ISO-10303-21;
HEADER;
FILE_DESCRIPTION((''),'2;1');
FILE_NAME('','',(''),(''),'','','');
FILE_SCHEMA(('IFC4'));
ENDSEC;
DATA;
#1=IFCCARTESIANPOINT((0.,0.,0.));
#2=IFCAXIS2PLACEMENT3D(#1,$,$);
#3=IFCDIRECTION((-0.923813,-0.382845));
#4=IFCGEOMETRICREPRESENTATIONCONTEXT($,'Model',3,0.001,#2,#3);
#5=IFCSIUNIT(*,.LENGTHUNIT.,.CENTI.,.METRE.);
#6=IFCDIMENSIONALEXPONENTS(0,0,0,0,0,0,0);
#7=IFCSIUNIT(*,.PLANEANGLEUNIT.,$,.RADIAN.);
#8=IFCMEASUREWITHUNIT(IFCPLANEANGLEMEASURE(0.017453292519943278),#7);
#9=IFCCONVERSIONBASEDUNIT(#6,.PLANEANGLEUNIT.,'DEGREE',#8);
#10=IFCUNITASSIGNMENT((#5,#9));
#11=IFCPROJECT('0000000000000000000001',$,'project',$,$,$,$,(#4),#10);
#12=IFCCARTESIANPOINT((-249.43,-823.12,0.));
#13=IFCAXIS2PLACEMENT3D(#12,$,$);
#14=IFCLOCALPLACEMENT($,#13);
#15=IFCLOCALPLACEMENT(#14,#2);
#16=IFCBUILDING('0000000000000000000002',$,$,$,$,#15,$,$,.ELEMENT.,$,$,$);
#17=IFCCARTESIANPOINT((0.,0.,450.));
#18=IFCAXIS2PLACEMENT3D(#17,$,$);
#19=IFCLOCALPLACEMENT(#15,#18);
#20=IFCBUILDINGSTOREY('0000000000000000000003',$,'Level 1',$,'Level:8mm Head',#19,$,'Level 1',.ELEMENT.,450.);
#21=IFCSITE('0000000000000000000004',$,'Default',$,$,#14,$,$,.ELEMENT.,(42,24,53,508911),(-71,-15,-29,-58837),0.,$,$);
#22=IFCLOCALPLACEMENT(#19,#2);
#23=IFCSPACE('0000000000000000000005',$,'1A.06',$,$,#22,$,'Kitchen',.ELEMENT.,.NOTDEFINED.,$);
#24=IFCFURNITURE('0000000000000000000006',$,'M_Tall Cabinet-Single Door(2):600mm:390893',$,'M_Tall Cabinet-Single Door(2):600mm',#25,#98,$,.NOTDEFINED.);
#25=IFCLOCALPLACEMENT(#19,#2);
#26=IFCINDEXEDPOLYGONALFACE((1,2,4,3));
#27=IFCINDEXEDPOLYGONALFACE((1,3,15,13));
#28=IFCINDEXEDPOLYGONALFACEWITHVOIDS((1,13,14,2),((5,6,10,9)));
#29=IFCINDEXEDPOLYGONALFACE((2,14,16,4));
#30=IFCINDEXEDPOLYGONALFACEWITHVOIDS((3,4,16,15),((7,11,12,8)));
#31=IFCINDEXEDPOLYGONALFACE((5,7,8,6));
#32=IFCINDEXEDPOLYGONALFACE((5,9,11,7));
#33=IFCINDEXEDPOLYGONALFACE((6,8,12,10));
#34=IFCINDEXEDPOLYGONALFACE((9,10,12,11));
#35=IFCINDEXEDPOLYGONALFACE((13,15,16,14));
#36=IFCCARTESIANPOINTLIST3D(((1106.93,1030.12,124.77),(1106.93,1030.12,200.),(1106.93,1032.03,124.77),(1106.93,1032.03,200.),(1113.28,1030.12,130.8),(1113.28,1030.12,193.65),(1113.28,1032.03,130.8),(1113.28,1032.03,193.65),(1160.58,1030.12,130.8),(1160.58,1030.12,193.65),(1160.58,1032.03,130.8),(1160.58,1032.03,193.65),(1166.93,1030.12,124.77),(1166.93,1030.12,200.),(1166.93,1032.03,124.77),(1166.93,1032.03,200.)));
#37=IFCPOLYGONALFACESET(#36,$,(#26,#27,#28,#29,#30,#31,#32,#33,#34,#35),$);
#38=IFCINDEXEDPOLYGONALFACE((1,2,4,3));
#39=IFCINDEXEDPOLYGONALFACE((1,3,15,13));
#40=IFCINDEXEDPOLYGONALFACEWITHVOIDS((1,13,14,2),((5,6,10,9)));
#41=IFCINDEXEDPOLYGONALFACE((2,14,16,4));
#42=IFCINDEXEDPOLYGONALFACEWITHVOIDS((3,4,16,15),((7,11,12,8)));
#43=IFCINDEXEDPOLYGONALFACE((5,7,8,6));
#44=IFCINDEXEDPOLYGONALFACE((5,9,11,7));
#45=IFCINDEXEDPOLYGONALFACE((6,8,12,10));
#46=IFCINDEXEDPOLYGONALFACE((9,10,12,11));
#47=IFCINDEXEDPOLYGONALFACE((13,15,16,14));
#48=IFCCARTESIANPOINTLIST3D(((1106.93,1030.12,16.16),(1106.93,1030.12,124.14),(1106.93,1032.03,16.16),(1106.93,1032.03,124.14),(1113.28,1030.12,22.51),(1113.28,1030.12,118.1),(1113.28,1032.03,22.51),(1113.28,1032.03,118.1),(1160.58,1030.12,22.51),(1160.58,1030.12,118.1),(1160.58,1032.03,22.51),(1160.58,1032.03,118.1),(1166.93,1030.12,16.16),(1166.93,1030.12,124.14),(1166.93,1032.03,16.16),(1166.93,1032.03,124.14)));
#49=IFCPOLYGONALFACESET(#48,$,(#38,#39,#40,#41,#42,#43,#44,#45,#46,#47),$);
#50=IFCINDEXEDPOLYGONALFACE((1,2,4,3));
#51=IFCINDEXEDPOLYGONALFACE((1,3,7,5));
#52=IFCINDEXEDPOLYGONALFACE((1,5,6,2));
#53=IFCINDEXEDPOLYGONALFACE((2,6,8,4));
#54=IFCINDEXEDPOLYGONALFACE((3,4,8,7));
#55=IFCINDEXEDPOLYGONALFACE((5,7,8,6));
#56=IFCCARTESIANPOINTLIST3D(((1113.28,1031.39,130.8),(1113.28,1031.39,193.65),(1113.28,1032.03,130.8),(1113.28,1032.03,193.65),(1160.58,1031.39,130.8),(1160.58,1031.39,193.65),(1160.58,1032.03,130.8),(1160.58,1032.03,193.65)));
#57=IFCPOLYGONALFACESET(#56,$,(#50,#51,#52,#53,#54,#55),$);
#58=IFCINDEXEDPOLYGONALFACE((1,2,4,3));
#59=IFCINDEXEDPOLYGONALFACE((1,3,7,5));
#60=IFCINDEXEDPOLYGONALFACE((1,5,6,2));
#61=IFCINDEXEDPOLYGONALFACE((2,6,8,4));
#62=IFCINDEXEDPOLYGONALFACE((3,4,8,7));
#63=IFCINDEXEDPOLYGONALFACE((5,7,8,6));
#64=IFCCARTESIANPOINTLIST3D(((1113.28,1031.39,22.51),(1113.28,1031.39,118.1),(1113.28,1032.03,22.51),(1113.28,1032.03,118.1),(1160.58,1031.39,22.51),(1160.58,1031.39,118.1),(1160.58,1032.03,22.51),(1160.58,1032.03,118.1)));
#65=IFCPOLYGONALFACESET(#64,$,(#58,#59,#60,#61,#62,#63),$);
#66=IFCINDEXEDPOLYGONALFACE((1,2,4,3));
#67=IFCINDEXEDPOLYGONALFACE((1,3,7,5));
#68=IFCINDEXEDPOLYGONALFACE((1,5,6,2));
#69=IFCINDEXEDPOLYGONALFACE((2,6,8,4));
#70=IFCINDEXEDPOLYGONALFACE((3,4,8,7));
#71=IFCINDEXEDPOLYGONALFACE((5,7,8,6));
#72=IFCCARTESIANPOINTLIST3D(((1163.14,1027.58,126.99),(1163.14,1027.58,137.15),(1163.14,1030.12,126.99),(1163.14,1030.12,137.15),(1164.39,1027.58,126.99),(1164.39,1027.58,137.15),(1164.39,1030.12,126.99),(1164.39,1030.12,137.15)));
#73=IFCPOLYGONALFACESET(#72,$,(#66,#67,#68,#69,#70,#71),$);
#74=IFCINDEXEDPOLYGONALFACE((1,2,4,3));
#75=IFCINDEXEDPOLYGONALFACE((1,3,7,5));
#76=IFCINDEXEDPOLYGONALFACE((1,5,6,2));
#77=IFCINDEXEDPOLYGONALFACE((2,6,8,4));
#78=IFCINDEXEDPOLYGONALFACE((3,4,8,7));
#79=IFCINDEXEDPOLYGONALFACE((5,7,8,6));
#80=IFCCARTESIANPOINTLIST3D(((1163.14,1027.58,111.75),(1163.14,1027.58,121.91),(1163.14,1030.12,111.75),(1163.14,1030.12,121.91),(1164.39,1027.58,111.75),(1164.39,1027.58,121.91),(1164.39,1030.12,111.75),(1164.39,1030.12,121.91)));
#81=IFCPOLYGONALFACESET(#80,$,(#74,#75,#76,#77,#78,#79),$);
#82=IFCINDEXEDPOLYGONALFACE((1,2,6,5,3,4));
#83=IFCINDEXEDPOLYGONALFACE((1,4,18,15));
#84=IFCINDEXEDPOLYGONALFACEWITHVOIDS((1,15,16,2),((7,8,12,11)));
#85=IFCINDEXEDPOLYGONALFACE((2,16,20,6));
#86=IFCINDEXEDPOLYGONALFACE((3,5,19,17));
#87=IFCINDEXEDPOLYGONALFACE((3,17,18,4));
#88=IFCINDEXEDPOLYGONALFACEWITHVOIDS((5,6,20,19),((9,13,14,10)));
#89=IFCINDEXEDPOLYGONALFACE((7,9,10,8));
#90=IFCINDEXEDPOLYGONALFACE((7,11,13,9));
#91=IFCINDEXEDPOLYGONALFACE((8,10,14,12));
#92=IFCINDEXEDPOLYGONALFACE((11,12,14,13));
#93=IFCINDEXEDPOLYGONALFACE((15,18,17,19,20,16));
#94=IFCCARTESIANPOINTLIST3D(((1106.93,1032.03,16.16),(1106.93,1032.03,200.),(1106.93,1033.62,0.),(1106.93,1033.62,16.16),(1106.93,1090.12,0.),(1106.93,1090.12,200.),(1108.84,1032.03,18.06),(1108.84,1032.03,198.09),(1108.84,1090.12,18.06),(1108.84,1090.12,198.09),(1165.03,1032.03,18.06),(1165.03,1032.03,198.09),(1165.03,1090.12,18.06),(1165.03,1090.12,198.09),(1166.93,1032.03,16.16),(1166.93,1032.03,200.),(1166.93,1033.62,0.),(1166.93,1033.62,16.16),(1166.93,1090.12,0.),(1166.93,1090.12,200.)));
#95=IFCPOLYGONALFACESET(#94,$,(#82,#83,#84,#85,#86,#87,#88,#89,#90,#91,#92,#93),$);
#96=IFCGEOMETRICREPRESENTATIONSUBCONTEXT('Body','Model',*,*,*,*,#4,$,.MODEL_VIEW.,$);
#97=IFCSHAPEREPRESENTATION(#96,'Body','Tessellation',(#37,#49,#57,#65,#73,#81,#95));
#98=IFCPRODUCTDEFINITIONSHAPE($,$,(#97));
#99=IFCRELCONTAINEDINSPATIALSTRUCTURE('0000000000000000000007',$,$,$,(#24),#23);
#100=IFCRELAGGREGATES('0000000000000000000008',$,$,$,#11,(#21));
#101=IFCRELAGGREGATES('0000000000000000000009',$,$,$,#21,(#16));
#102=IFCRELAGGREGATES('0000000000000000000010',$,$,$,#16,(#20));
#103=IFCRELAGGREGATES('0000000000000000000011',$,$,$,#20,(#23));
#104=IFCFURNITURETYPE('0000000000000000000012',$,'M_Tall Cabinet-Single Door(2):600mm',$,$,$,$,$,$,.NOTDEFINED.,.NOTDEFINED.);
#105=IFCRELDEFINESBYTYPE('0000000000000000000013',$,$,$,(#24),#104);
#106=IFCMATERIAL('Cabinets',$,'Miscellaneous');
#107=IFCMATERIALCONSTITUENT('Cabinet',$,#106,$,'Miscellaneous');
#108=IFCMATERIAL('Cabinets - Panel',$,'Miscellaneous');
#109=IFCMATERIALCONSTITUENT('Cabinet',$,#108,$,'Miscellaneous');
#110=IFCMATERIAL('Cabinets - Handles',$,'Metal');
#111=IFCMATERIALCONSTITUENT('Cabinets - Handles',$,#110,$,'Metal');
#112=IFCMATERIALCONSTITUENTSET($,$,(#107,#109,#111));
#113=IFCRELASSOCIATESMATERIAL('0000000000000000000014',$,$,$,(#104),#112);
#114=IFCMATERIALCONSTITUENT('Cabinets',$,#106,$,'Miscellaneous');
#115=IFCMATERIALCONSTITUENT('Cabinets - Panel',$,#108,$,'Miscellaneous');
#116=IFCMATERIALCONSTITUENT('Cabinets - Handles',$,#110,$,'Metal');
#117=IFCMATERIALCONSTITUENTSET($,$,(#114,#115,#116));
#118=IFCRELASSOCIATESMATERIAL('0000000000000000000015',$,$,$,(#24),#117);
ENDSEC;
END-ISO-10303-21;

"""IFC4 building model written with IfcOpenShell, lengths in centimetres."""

from ifc_helpers import new_model, entity, si_unit, converted_unit, direction, frame, origin, place, context, subcontext, project, spatial, indexed_curve, outline, extrude, source, transform, mapped, material, constituent, constituent_set, type_object, type_shapes, element, save


model = new_model("IFC4")

# Units and contexts
model_context = context("Model", 3, precision=0.001, world=origin(), true_north=direction((-0.923813, -0.382845)))
body_context = subcontext(model_context, "Body", "Model", "MODEL_VIEW")
ifc_project = project(units=[si_unit("LENGTHUNIT", "METRE", prefix="CENTI"), converted_unit("PLANEANGLEUNIT", "DEGREE", entity("IfcPlaneAngleMeasure", 0.017453292519943278), si_unit("PLANEANGLEUNIT", "RADIAN"), dimensions=[0, 0, 0, 0, 0, 0, 0])], contexts=[model_context])

# Site, building, storey
site_placement = place(None, frame((-249.43, -823.12, 0.0)))
site = spatial("IfcSite", under=ifc_project, at=site_placement, Name="Default", CompositionType="ELEMENT", RefLatitude=(42, 24, 53, 508911), RefLongitude=(-71, -15, -29, -58837), RefElevation=0.0)
building_placement = place(site_placement, origin())
building = spatial("IfcBuilding", under=site, at=building_placement, CompositionType="ELEMENT")
storey_placement = place(building_placement, frame((0.0, 0.0, 450.0)))
storey = spatial("IfcBuildingStorey", under=building, at=storey_placement, Name="Level 1", ObjectType="Level:8mm Head", LongName="Level 1", CompositionType="ELEMENT", Elevation=450.0)

# Shared definitions
space_1_placement = place(storey_placement, origin())
space_1 = spatial("IfcSpace", under=storey, at=space_1_placement, Name="1A.06", LongName="Kitchen", CompositionType="ELEMENT", PredefinedType="NOTDEFINED")

# Furniture, opening
ifc_material_1 = material(Name="Cabinets", Category="Miscellaneous")
ifc_material_2 = material(Name="Cabinets - Panel", Category="Miscellaneous")
ifc_material_3 = material(Name="Cabinets - Handles", Category="Metal")
ifc_constituent_1 = constituent(ifc_material_1, Name="Cabinets", Category="Miscellaneous")
ifc_constituent_2 = constituent(ifc_material_2, Name="Cabinets - Panel", Category="Miscellaneous")
ifc_constituent_3 = constituent(ifc_material_3, Name="Cabinets - Handles", Category="Metal")
ifc_constituent_set_1 = constituent_set(constituents=[ifc_constituent_1, ifc_constituent_2, ifc_constituent_3])
ifc_constituent_4 = constituent(ifc_material_1, Name="Cabinet", Category="Miscellaneous")
ifc_constituent_5 = constituent(ifc_material_2, Name="Cabinet", Category="Miscellaneous")
ifc_constituent_6 = constituent(ifc_material_3, Name="Cabinets - Handles", Category="Metal")
ifc_constituent_set_2 = constituent_set(constituents=[ifc_constituent_4, ifc_constituent_5, ifc_constituent_6])
furniture_type_1 = type_object("IfcFurnitureType", Name="M_Tall Cabinet-Single Door(2):600mm", AssemblyPlace="NOTDEFINED", PredefinedType="NOTDEFINED", material=ifc_constituent_set_2)
shared_shape_1 = source(origin(), body_context, "Body", "SweptSolid", [
    extrude(outline(indexed_curve([(-0.95, -28.09), (0.95, -28.09), (0.95, 28.09), (-0.95, 28.09), (-0.95, -28.09)], self_intersect=False)), frame((1.87, -0.95, 18.06), z_axis=(0.0, 0.0, 1.0), x_axis=(0.0, 1.0, 0.0)), (0.0, 0.0, 1.0), 180.03),
    extrude(outline(indexed_curve([(-37.61, -30.0), (37.61, -30.0), (37.61, 30.0), (-37.61, 30.0), (-37.61, -30.0)], self_intersect=False), holes=[indexed_curve([(-31.26, -23.65), (-31.26, 23.65), (31.58, 23.65), (31.58, -23.65), (-31.26, -23.65)], self_intersect=False)]), frame((1.87, -60.0, 162.39), z_axis=(0.0, 1.0, 0.0), x_axis=(0.0, 0.0, -1.0)), (0.0, 0.0, 1.0), 1.91),
    extrude(outline(indexed_curve([(-30.0, -53.99), (30.0, -53.99), (30.0, 53.99), (-30.0, 53.99), (-30.0, -53.99)], self_intersect=False), holes=[indexed_curve([(-23.65, 47.96), (23.65, 47.96), (23.65, -47.64), (-23.65, -47.64), (-23.65, 47.96)], self_intersect=False)]), frame((1.87, -60.0, 70.15), z_axis=(0.0, 1.0, 0.0), x_axis=(-1.0, 0.0, 0.0)), (0.0, 0.0, 1.0), 1.91),
    extrude(outline(indexed_curve([(-0.32, -23.65), (0.32, -23.65), (0.32, 23.65), (-0.32, 23.65), (-0.32, -23.65)], self_intersect=False)), frame((1.87, -58.41, 130.8), z_axis=(0.0, 0.0, 1.0), x_axis=(0.0, 1.0, 0.0)), (0.0, 0.0, 1.0), 62.85),
    extrude(outline(indexed_curve([(-0.32, -23.65), (0.32, -23.65), (0.32, 23.65), (-0.32, 23.65), (-0.32, -23.65)], self_intersect=False)), frame((1.87, -58.41, 22.51), z_axis=(0.0, 0.0, 1.0), x_axis=(0.0, 1.0, 0.0)), (0.0, 0.0, 1.0), 95.6),
    extrude(outline(indexed_curve([(-1.27, -0.63), (1.27, -0.63), (1.27, 0.63), (-1.27, 0.63), (-1.27, -0.63)], self_intersect=False)), frame((28.71, -61.27, 126.99), z_axis=(0.0, 0.0, 1.0), x_axis=(0.0, 1.0, 0.0)), (0.0, 0.0, 1.0), 10.16),
    extrude(outline(indexed_curve([(-1.27, -0.63), (1.27, -0.63), (1.27, 0.63), (-1.27, 0.63), (-1.27, -0.63)], self_intersect=False)), frame((28.71, -61.27, 111.75), z_axis=(0.0, 0.0, 1.0), x_axis=(0.0, 1.0, 0.0)), (0.0, 0.0, 1.0), 10.16),
    extrude(outline(indexed_curve([(-19.9, 55.89), (-19.9, -127.95), (38.2, -127.95), (38.2, 72.05), (-18.3, 72.05), (-18.3, 55.89), (-19.9, 55.89)], self_intersect=False)), frame((-28.13, -38.2, 72.05), z_axis=(-1.0, 0.0, 0.0), x_axis=(0.0, 1.0, 0.0)), (0.0, 0.0, -1.0), 60.0),
])
type_shapes(furniture_type_1, [shared_shape_1])
furniture_1_placement = place(space_1_placement, frame((1135.06, 1090.12, 0.0)))
furniture_1 = element("IfcFurniture", 1, at=furniture_1_placement, inside=space_1, type_object=furniture_type_1, material=ifc_constituent_set_1, Name="M_Tall Cabinet-Single Door(2):600mm:390893", ObjectType="M_Tall Cabinet-Single Door(2):600mm", PredefinedType="NOTDEFINED", context=body_context, shape_type="MappedRepresentation", body=[
    mapped(shared_shape_1, transform((0.0, 0.0, 0.0), scale=1.0)),
])
opening_1_placement = place(storey_placement, frame((1135.06, 1090.12, 450.0)))
element("IfcOpeningElement", 2, at=opening_1_placement, cuts=furniture_1, PredefinedType="OPENING", context=body_context, shape_type="SweptSolid", body=[
    extrude(outline(indexed_curve([(-90.02, -28.09), (90.02, -28.09), (90.02, 28.09), (-90.02, 28.09), (-90.02, -28.09)], self_intersect=False)), frame((1.87, -58.09, -341.92), z_axis=(0.0, 1.0, 0.0), x_axis=(0.0, 0.0, -1.0)), (0.0, 0.0, 1.0), 58.09),
])

save(model, "model.ifc")
